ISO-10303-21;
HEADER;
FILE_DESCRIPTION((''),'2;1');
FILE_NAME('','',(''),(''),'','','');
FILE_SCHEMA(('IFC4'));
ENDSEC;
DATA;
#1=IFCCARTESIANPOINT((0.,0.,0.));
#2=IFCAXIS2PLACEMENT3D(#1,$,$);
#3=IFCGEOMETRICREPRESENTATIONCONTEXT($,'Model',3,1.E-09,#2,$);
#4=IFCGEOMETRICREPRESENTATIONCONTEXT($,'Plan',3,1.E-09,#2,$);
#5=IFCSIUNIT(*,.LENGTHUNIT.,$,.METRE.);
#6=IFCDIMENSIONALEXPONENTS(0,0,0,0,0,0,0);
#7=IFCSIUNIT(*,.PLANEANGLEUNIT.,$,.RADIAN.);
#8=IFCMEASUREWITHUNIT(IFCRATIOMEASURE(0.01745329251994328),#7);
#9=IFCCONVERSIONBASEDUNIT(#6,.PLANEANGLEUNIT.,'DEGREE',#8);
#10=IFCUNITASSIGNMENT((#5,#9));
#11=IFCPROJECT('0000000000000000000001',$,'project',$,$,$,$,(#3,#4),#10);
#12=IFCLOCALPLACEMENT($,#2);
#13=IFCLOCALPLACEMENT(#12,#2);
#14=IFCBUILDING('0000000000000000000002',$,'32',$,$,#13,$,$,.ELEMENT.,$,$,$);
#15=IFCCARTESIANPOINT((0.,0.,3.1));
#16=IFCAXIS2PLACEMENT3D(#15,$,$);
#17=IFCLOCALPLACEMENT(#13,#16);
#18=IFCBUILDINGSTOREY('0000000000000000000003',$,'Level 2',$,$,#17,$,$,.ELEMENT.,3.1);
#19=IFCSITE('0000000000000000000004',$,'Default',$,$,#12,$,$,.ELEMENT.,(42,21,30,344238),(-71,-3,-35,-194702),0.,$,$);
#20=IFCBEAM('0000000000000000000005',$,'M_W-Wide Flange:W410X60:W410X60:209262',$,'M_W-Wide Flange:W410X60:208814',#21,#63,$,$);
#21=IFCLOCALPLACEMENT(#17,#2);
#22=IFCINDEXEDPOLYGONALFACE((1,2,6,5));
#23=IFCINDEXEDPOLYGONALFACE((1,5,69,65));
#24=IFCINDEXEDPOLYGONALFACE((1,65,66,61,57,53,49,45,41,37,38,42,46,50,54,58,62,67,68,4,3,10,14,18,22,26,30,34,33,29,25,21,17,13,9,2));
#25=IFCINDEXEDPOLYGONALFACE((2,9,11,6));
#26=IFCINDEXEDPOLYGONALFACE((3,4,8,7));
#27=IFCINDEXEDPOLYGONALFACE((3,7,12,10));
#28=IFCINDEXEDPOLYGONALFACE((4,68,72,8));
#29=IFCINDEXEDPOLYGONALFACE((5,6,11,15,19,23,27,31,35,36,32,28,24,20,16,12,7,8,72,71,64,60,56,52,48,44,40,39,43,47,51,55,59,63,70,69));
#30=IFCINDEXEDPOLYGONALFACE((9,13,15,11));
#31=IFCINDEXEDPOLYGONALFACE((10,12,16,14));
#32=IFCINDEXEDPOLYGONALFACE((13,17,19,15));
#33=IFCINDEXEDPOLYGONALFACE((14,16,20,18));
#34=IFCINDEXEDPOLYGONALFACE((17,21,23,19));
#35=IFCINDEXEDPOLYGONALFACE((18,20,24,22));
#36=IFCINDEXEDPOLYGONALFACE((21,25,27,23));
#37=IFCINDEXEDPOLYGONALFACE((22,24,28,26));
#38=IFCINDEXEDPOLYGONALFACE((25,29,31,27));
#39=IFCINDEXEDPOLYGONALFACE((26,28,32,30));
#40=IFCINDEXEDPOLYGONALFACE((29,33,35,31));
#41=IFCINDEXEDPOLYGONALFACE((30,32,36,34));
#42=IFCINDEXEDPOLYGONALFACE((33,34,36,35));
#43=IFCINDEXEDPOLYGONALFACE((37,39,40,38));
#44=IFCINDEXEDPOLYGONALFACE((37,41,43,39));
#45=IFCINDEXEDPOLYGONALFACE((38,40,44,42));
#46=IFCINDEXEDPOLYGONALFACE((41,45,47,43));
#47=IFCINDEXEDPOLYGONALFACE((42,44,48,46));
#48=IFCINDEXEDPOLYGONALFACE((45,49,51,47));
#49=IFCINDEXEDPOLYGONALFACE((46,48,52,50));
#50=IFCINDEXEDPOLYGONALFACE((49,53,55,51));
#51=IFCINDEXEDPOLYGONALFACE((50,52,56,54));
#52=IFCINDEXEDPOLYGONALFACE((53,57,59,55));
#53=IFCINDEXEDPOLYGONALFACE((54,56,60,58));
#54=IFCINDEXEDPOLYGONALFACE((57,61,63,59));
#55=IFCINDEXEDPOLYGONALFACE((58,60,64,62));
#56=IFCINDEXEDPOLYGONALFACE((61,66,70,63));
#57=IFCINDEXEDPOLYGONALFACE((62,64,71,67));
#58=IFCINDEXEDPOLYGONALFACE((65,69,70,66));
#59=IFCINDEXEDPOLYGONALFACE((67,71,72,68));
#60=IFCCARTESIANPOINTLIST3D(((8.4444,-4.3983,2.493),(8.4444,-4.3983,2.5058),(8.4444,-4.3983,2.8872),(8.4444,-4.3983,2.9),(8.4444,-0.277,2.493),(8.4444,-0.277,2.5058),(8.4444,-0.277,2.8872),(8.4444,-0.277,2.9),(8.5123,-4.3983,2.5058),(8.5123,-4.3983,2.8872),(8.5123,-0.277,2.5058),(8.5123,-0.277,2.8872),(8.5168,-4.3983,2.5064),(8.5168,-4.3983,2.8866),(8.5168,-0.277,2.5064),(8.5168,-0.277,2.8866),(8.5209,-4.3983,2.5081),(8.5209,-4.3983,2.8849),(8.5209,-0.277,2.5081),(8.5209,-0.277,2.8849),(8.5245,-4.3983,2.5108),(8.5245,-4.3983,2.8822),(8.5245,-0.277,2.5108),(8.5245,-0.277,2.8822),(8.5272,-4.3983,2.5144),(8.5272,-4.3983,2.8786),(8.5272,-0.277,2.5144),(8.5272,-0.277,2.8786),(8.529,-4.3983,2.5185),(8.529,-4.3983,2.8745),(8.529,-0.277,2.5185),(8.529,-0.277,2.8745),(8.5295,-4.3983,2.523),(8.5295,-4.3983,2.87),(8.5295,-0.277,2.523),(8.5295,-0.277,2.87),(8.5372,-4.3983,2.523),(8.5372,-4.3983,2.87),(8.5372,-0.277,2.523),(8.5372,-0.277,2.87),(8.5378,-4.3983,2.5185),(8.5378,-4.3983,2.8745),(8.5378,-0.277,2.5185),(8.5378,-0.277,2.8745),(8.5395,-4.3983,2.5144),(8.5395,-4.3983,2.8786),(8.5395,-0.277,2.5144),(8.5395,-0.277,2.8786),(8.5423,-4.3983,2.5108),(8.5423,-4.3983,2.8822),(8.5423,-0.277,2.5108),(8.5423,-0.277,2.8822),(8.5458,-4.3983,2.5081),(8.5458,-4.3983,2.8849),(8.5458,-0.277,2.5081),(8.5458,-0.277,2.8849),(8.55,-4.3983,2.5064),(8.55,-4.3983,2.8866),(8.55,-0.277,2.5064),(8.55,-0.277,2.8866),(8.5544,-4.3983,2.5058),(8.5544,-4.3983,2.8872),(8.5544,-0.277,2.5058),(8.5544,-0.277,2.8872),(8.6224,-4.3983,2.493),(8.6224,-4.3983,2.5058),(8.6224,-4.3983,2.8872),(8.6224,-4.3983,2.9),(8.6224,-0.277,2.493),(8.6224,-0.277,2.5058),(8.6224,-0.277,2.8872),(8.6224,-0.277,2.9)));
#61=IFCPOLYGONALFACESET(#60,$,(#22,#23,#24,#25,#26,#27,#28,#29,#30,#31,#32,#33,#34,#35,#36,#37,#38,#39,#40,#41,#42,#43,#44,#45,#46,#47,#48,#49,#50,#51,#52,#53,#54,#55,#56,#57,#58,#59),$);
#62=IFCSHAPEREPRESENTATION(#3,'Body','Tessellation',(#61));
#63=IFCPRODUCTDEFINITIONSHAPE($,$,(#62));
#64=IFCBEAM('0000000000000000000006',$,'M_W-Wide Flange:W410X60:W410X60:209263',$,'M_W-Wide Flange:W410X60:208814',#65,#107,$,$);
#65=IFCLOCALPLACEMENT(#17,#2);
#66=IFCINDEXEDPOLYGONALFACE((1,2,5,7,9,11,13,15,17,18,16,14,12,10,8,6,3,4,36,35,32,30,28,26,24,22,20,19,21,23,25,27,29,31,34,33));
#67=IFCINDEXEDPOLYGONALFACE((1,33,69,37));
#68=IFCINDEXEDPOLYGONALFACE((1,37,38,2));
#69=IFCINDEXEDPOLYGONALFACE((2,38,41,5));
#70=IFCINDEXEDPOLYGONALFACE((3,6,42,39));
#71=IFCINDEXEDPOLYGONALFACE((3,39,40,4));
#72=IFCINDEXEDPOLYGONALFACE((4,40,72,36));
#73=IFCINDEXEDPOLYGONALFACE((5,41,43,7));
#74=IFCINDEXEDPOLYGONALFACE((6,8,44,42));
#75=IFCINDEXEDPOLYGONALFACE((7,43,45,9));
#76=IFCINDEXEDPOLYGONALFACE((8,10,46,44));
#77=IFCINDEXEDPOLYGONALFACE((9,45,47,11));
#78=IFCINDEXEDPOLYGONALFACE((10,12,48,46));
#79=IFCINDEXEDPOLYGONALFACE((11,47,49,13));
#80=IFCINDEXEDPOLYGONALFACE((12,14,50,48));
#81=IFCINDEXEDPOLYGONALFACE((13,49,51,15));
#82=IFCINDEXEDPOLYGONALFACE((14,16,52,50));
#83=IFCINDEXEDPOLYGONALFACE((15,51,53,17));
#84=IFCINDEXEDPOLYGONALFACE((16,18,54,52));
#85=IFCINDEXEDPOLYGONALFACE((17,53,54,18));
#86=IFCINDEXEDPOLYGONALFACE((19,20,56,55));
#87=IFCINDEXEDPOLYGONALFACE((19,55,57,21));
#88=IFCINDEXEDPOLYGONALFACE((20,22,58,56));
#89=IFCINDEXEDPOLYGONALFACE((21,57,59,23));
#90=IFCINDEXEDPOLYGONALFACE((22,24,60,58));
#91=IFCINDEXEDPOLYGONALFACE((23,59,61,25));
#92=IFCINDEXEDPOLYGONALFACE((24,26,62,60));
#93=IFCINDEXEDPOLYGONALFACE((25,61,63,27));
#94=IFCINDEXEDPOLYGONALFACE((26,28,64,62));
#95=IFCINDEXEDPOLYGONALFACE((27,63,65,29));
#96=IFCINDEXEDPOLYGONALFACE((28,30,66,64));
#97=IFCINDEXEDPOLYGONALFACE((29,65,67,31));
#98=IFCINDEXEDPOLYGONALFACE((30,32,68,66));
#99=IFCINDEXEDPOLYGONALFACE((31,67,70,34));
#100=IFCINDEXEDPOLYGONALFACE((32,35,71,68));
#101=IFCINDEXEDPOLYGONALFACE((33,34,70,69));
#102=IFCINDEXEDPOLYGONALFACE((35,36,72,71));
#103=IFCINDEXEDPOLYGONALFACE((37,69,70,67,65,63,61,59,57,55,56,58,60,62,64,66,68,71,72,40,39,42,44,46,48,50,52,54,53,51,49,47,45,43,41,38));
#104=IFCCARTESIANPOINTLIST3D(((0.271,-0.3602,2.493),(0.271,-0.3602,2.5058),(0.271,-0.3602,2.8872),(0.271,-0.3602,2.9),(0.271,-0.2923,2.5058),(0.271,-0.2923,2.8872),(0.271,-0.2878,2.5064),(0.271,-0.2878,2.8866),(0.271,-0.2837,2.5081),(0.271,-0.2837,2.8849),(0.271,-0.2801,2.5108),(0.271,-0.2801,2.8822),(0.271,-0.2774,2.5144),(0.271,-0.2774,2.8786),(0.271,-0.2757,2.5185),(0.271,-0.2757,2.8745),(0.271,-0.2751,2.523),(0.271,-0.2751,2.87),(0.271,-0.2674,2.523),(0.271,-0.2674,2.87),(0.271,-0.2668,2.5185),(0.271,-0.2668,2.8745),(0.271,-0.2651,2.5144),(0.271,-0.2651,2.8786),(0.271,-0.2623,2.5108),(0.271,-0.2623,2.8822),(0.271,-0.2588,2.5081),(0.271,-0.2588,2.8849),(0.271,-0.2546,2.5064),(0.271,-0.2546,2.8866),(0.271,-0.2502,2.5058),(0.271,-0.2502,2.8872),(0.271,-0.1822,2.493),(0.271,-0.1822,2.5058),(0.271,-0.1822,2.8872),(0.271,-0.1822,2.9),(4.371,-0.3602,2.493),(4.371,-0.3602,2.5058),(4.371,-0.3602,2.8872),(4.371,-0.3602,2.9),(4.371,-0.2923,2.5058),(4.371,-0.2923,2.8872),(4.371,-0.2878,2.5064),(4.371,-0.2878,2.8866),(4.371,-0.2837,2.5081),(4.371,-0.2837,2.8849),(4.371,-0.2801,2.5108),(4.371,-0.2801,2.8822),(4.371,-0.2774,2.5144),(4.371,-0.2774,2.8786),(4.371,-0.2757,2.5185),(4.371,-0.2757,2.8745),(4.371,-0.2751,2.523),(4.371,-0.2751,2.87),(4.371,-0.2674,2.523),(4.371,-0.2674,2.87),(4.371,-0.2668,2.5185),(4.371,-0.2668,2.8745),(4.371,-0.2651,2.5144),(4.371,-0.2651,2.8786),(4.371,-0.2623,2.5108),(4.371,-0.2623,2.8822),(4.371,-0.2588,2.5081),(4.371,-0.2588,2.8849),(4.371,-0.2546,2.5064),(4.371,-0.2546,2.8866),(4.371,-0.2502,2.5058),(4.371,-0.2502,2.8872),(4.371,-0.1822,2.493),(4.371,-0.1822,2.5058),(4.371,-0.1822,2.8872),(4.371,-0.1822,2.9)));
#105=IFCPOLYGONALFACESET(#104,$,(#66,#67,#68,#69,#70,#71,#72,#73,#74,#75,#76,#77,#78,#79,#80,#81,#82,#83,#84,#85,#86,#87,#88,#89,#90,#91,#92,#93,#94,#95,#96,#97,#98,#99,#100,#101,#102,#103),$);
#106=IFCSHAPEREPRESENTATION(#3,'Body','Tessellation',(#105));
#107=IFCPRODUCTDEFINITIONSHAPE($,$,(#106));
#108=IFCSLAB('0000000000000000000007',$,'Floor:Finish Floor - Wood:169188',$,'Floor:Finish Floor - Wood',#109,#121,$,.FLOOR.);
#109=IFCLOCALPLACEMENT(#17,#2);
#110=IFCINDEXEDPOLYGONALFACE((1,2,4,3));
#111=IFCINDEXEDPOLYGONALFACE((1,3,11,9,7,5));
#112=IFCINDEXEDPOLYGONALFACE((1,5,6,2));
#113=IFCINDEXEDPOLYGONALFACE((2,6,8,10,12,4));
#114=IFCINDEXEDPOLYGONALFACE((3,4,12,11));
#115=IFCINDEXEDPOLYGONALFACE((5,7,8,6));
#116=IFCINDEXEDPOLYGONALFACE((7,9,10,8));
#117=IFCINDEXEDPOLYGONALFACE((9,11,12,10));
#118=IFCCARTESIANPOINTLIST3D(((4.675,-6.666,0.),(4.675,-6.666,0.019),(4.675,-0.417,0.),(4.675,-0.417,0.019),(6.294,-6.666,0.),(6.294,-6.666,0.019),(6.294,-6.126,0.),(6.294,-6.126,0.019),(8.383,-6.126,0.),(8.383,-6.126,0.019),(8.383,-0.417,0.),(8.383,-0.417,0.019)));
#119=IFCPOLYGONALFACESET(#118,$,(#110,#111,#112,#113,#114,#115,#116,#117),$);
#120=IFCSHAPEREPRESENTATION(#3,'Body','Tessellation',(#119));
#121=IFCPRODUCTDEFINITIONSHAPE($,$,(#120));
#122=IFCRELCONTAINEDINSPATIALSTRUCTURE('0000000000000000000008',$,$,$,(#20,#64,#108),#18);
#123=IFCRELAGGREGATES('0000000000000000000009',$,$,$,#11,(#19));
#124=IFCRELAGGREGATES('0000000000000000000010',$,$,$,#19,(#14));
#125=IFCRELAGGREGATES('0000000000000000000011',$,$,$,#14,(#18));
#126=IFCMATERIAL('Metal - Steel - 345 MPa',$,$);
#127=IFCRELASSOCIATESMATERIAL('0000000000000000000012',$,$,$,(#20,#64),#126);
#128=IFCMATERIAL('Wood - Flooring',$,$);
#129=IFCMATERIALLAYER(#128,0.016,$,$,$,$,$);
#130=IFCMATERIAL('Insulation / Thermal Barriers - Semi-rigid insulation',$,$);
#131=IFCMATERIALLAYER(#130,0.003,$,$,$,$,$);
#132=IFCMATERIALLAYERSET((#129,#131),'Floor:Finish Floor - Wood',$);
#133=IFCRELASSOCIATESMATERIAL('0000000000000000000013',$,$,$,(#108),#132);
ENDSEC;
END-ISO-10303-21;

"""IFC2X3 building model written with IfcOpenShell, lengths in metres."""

from ifc_helpers import new_model, entity, si_unit, converted_unit, frame, frame_2d, origin, place, context, project, spatial, polyline, circle_curve, parameter, trimmed, segment, composite_curve, outline, extrude, material, layer, layer_set, layer_usage, element, save


model = new_model("IFC2X3")

# Units and contexts
model_context = context("Model", 3, precision=1e-09, world=origin())
plan_context = context("Plan", 3, precision=1e-09, world=origin())
ifc_project = project(units=[si_unit("LENGTHUNIT", "METRE"), converted_unit("PLANEANGLEUNIT", "DEGREE", entity("IfcRatioMeasure", 0.01745329251994328), si_unit("PLANEANGLEUNIT", "RADIAN"), dimensions=[0, 0, 0, 0, 0, 0, 0])], contexts=[model_context, plan_context])

# Site, building, storey
site_placement = place(None, origin())
site = spatial("IfcSite", under=ifc_project, at=site_placement, Name="Default", CompositionType="ELEMENT", RefLatitude=(42, 21, 30, 344238), RefLongitude=(-71, -3, -35, -194702), RefElevation=0.0)
building_placement = place(site_placement, origin())
building = spatial("IfcBuilding", under=site, at=building_placement, Name="32", CompositionType="ELEMENT")
storey_placement = place(building_placement, frame((0.0, 0.0, 3.1)))
storey = spatial("IfcBuildingStorey", under=building, at=storey_placement, Name="Level 2", CompositionType="ELEMENT", Elevation=3.1)

# Beams
ifc_material_1 = material(Name="Metal - Steel - 345 MPa")
beam_1_placement = place(storey_placement, frame((8.5334, -4.3983, 2.9)))
element("IfcBeam", 1, at=beam_1_placement, inside=storey, material=ifc_material_1, Name="M_W-Wide Flange:W410X60:W410X60:209262", ObjectType="M_W-Wide Flange:W410X60:208814", context=model_context, shape_type="SweptSolid", body=[
    extrude(outline(composite_curve([segment(polyline([(-0.089, -0.1907), (-0.089, -0.2035)]), True, "CONTINUOUS"), segment(polyline([(-0.089, -0.2035), (0.089, -0.2035)]), True, "CONTINUOUS"), segment(polyline([(0.089, -0.2035), (0.089, -0.1907)]), True, "CONTINUOUS"), segment(polyline([(0.089, -0.1907), (0.021, -0.1907)]), True, "CONTINUOUS"), segment(trimmed(circle_curve(frame_2d((0.021, -0.1735), x_axis=(0.0, -1.0)), 0.0172), [parameter(270.0)], [parameter(360.0)], True, "PARAMETER"), False, "CONTINUOUS"), segment(polyline([(0.0038, -0.1735), (0.0038, 0.1735)]), True, "CONTINUOUS"), segment(trimmed(circle_curve(frame_2d((0.021, 0.1735), x_axis=(-1.0, 0.0)), 0.0172), [parameter(270.0)], [parameter(360.0)], True, "PARAMETER"), False, "CONTINUOUS"), segment(polyline([(0.021, 0.1907), (0.089, 0.1907)]), True, "CONTINUOUS"), segment(polyline([(0.089, 0.1907), (0.089, 0.2035)]), True, "CONTINUOUS"), segment(polyline([(0.089, 0.2035), (-0.089, 0.2035)]), True, "CONTINUOUS"), segment(polyline([(-0.089, 0.2035), (-0.089, 0.1907)]), True, "CONTINUOUS"), segment(polyline([(-0.089, 0.1907), (-0.0211, 0.1907)]), True, "CONTINUOUS"), segment(trimmed(circle_curve(frame_2d((-0.0211, 0.1735), x_axis=(0.0, 1.0)), 0.0172), [parameter(270.0)], [parameter(0.0)], True, "PARAMETER"), False, "CONTINUOUS"), segment(polyline([(-0.0039, 0.1735), (-0.0039, -0.1735)]), True, "CONTINUOUS"), segment(trimmed(circle_curve(frame_2d((-0.0211, -0.1735), x_axis=(1.0, 0.0)), 0.0172), [parameter(270.0)], [parameter(0.0)], True, "PARAMETER"), False, "CONTINUOUS"), segment(polyline([(-0.0211, -0.1907), (-0.089, -0.1907)]), True, "CONTINUOUS")], self_intersect=False)), frame((0.0, 0.0, -0.2035), z_axis=(0.0, -1.0, 0.0), x_axis=(1.0, 0.0, 0.0)), (0.0, 0.0, -1.0), 4.1213),
])
beam_2_placement = place(storey_placement, frame((4.371, -0.2712, 2.9), z_axis=(0.0, 0.0, 1.0), x_axis=(0.0, 1.0, 0.0)))
element("IfcBeam", 2, at=beam_2_placement, inside=storey, material=ifc_material_1, Name="M_W-Wide Flange:W410X60:W410X60:209263", ObjectType="M_W-Wide Flange:W410X60:208814", context=model_context, shape_type="SweptSolid", body=[
    extrude(outline(composite_curve([segment(polyline([(0.1907, -0.089), (0.2035, -0.089)]), True, "CONTINUOUS"), segment(polyline([(0.2035, -0.089), (0.2035, 0.089)]), True, "CONTINUOUS"), segment(polyline([(0.2035, 0.089), (0.1907, 0.089)]), True, "CONTINUOUS"), segment(polyline([(0.1907, 0.089), (0.1907, 0.0211)]), True, "CONTINUOUS"), segment(trimmed(circle_curve(frame_2d((0.1735, 0.0211), x_axis=(1.0, 0.0)), 0.0172), [parameter(270.0)], [parameter(360.0)], True, "PARAMETER"), False, "CONTINUOUS"), segment(polyline([(0.1735, 0.0039), (-0.1735, 0.0039)]), True, "CONTINUOUS"), segment(trimmed(circle_curve(frame_2d((-0.1735, 0.0211), x_axis=(0.0, -1.0)), 0.0172), [parameter(270.0)], [parameter(360.0)], True, "PARAMETER"), False, "CONTINUOUS"), segment(polyline([(-0.1907, 0.0211), (-0.1907, 0.089)]), True, "CONTINUOUS"), segment(polyline([(-0.1907, 0.089), (-0.2035, 0.089)]), True, "CONTINUOUS"), segment(polyline([(-0.2035, 0.089), (-0.2035, -0.089)]), True, "CONTINUOUS"), segment(polyline([(-0.2035, -0.089), (-0.1907, -0.089)]), True, "CONTINUOUS"), segment(polyline([(-0.1907, -0.089), (-0.1907, -0.0211)]), True, "CONTINUOUS"), segment(trimmed(circle_curve(frame_2d((-0.1735, -0.0211), x_axis=(-1.0, 0.0)), 0.0172), [parameter(270.0)], [parameter(0.0)], True, "PARAMETER"), False, "CONTINUOUS"), segment(polyline([(-0.1735, -0.0039), (0.1735, -0.0039)]), True, "CONTINUOUS"), segment(trimmed(circle_curve(frame_2d((0.1735, -0.0211), x_axis=(0.0, 1.0)), 0.0172), [parameter(270.0)], [parameter(0.0)], True, "PARAMETER"), False, "CONTINUOUS"), segment(polyline([(0.1907, -0.0211), (0.1907, -0.089)]), True, "CONTINUOUS")], self_intersect=False)), frame((0.0, 4.1, -0.2035), z_axis=(0.0, -1.0, 0.0), x_axis=(0.0, 0.0, -1.0)), (0.0, 0.0, 1.0), 4.1),
])

# Slab
ifc_material_2 = material(Name="Wood - Flooring")
ifc_layer_1 = layer(ifc_material_2, 0.016)
ifc_material_3 = material(Name="Insulation / Thermal Barriers - Semi-rigid insulation")
ifc_layer_2 = layer(ifc_material_3, 0.003)
ifc_layer_set_1 = layer_set([ifc_layer_1, ifc_layer_2], Name="Floor:Finish Floor - Wood")
ifc_layer_usage_1 = layer_usage(ifc_layer_set_1, "AXIS3", "POSITIVE", 0.0)
slab_placement = place(storey_placement, frame((4.675, -6.666, 0.0)))
element("IfcSlab", 3, at=slab_placement, inside=storey, material=ifc_layer_usage_1, Name="Floor:Finish Floor - Wood:169188", ObjectType="Floor:Finish Floor - Wood", PredefinedType="FLOOR", context=model_context, shape_type="SweptSolid", body=[
    extrude(outline(polyline([(-1.854, 3.1245), (-1.854, -2.5845), (0.235, -2.5845), (0.235, -3.1245), (1.854, -3.1245), (1.854, 3.1245), (-1.854, 3.1245)])), frame((1.854, 3.1245, 0.019), z_axis=(0.0, 0.0, -1.0), x_axis=(-1.0, 0.0, 0.0)), (0.0, 0.0, 1.0), 0.019),
])

save(model, "model.ifc")
